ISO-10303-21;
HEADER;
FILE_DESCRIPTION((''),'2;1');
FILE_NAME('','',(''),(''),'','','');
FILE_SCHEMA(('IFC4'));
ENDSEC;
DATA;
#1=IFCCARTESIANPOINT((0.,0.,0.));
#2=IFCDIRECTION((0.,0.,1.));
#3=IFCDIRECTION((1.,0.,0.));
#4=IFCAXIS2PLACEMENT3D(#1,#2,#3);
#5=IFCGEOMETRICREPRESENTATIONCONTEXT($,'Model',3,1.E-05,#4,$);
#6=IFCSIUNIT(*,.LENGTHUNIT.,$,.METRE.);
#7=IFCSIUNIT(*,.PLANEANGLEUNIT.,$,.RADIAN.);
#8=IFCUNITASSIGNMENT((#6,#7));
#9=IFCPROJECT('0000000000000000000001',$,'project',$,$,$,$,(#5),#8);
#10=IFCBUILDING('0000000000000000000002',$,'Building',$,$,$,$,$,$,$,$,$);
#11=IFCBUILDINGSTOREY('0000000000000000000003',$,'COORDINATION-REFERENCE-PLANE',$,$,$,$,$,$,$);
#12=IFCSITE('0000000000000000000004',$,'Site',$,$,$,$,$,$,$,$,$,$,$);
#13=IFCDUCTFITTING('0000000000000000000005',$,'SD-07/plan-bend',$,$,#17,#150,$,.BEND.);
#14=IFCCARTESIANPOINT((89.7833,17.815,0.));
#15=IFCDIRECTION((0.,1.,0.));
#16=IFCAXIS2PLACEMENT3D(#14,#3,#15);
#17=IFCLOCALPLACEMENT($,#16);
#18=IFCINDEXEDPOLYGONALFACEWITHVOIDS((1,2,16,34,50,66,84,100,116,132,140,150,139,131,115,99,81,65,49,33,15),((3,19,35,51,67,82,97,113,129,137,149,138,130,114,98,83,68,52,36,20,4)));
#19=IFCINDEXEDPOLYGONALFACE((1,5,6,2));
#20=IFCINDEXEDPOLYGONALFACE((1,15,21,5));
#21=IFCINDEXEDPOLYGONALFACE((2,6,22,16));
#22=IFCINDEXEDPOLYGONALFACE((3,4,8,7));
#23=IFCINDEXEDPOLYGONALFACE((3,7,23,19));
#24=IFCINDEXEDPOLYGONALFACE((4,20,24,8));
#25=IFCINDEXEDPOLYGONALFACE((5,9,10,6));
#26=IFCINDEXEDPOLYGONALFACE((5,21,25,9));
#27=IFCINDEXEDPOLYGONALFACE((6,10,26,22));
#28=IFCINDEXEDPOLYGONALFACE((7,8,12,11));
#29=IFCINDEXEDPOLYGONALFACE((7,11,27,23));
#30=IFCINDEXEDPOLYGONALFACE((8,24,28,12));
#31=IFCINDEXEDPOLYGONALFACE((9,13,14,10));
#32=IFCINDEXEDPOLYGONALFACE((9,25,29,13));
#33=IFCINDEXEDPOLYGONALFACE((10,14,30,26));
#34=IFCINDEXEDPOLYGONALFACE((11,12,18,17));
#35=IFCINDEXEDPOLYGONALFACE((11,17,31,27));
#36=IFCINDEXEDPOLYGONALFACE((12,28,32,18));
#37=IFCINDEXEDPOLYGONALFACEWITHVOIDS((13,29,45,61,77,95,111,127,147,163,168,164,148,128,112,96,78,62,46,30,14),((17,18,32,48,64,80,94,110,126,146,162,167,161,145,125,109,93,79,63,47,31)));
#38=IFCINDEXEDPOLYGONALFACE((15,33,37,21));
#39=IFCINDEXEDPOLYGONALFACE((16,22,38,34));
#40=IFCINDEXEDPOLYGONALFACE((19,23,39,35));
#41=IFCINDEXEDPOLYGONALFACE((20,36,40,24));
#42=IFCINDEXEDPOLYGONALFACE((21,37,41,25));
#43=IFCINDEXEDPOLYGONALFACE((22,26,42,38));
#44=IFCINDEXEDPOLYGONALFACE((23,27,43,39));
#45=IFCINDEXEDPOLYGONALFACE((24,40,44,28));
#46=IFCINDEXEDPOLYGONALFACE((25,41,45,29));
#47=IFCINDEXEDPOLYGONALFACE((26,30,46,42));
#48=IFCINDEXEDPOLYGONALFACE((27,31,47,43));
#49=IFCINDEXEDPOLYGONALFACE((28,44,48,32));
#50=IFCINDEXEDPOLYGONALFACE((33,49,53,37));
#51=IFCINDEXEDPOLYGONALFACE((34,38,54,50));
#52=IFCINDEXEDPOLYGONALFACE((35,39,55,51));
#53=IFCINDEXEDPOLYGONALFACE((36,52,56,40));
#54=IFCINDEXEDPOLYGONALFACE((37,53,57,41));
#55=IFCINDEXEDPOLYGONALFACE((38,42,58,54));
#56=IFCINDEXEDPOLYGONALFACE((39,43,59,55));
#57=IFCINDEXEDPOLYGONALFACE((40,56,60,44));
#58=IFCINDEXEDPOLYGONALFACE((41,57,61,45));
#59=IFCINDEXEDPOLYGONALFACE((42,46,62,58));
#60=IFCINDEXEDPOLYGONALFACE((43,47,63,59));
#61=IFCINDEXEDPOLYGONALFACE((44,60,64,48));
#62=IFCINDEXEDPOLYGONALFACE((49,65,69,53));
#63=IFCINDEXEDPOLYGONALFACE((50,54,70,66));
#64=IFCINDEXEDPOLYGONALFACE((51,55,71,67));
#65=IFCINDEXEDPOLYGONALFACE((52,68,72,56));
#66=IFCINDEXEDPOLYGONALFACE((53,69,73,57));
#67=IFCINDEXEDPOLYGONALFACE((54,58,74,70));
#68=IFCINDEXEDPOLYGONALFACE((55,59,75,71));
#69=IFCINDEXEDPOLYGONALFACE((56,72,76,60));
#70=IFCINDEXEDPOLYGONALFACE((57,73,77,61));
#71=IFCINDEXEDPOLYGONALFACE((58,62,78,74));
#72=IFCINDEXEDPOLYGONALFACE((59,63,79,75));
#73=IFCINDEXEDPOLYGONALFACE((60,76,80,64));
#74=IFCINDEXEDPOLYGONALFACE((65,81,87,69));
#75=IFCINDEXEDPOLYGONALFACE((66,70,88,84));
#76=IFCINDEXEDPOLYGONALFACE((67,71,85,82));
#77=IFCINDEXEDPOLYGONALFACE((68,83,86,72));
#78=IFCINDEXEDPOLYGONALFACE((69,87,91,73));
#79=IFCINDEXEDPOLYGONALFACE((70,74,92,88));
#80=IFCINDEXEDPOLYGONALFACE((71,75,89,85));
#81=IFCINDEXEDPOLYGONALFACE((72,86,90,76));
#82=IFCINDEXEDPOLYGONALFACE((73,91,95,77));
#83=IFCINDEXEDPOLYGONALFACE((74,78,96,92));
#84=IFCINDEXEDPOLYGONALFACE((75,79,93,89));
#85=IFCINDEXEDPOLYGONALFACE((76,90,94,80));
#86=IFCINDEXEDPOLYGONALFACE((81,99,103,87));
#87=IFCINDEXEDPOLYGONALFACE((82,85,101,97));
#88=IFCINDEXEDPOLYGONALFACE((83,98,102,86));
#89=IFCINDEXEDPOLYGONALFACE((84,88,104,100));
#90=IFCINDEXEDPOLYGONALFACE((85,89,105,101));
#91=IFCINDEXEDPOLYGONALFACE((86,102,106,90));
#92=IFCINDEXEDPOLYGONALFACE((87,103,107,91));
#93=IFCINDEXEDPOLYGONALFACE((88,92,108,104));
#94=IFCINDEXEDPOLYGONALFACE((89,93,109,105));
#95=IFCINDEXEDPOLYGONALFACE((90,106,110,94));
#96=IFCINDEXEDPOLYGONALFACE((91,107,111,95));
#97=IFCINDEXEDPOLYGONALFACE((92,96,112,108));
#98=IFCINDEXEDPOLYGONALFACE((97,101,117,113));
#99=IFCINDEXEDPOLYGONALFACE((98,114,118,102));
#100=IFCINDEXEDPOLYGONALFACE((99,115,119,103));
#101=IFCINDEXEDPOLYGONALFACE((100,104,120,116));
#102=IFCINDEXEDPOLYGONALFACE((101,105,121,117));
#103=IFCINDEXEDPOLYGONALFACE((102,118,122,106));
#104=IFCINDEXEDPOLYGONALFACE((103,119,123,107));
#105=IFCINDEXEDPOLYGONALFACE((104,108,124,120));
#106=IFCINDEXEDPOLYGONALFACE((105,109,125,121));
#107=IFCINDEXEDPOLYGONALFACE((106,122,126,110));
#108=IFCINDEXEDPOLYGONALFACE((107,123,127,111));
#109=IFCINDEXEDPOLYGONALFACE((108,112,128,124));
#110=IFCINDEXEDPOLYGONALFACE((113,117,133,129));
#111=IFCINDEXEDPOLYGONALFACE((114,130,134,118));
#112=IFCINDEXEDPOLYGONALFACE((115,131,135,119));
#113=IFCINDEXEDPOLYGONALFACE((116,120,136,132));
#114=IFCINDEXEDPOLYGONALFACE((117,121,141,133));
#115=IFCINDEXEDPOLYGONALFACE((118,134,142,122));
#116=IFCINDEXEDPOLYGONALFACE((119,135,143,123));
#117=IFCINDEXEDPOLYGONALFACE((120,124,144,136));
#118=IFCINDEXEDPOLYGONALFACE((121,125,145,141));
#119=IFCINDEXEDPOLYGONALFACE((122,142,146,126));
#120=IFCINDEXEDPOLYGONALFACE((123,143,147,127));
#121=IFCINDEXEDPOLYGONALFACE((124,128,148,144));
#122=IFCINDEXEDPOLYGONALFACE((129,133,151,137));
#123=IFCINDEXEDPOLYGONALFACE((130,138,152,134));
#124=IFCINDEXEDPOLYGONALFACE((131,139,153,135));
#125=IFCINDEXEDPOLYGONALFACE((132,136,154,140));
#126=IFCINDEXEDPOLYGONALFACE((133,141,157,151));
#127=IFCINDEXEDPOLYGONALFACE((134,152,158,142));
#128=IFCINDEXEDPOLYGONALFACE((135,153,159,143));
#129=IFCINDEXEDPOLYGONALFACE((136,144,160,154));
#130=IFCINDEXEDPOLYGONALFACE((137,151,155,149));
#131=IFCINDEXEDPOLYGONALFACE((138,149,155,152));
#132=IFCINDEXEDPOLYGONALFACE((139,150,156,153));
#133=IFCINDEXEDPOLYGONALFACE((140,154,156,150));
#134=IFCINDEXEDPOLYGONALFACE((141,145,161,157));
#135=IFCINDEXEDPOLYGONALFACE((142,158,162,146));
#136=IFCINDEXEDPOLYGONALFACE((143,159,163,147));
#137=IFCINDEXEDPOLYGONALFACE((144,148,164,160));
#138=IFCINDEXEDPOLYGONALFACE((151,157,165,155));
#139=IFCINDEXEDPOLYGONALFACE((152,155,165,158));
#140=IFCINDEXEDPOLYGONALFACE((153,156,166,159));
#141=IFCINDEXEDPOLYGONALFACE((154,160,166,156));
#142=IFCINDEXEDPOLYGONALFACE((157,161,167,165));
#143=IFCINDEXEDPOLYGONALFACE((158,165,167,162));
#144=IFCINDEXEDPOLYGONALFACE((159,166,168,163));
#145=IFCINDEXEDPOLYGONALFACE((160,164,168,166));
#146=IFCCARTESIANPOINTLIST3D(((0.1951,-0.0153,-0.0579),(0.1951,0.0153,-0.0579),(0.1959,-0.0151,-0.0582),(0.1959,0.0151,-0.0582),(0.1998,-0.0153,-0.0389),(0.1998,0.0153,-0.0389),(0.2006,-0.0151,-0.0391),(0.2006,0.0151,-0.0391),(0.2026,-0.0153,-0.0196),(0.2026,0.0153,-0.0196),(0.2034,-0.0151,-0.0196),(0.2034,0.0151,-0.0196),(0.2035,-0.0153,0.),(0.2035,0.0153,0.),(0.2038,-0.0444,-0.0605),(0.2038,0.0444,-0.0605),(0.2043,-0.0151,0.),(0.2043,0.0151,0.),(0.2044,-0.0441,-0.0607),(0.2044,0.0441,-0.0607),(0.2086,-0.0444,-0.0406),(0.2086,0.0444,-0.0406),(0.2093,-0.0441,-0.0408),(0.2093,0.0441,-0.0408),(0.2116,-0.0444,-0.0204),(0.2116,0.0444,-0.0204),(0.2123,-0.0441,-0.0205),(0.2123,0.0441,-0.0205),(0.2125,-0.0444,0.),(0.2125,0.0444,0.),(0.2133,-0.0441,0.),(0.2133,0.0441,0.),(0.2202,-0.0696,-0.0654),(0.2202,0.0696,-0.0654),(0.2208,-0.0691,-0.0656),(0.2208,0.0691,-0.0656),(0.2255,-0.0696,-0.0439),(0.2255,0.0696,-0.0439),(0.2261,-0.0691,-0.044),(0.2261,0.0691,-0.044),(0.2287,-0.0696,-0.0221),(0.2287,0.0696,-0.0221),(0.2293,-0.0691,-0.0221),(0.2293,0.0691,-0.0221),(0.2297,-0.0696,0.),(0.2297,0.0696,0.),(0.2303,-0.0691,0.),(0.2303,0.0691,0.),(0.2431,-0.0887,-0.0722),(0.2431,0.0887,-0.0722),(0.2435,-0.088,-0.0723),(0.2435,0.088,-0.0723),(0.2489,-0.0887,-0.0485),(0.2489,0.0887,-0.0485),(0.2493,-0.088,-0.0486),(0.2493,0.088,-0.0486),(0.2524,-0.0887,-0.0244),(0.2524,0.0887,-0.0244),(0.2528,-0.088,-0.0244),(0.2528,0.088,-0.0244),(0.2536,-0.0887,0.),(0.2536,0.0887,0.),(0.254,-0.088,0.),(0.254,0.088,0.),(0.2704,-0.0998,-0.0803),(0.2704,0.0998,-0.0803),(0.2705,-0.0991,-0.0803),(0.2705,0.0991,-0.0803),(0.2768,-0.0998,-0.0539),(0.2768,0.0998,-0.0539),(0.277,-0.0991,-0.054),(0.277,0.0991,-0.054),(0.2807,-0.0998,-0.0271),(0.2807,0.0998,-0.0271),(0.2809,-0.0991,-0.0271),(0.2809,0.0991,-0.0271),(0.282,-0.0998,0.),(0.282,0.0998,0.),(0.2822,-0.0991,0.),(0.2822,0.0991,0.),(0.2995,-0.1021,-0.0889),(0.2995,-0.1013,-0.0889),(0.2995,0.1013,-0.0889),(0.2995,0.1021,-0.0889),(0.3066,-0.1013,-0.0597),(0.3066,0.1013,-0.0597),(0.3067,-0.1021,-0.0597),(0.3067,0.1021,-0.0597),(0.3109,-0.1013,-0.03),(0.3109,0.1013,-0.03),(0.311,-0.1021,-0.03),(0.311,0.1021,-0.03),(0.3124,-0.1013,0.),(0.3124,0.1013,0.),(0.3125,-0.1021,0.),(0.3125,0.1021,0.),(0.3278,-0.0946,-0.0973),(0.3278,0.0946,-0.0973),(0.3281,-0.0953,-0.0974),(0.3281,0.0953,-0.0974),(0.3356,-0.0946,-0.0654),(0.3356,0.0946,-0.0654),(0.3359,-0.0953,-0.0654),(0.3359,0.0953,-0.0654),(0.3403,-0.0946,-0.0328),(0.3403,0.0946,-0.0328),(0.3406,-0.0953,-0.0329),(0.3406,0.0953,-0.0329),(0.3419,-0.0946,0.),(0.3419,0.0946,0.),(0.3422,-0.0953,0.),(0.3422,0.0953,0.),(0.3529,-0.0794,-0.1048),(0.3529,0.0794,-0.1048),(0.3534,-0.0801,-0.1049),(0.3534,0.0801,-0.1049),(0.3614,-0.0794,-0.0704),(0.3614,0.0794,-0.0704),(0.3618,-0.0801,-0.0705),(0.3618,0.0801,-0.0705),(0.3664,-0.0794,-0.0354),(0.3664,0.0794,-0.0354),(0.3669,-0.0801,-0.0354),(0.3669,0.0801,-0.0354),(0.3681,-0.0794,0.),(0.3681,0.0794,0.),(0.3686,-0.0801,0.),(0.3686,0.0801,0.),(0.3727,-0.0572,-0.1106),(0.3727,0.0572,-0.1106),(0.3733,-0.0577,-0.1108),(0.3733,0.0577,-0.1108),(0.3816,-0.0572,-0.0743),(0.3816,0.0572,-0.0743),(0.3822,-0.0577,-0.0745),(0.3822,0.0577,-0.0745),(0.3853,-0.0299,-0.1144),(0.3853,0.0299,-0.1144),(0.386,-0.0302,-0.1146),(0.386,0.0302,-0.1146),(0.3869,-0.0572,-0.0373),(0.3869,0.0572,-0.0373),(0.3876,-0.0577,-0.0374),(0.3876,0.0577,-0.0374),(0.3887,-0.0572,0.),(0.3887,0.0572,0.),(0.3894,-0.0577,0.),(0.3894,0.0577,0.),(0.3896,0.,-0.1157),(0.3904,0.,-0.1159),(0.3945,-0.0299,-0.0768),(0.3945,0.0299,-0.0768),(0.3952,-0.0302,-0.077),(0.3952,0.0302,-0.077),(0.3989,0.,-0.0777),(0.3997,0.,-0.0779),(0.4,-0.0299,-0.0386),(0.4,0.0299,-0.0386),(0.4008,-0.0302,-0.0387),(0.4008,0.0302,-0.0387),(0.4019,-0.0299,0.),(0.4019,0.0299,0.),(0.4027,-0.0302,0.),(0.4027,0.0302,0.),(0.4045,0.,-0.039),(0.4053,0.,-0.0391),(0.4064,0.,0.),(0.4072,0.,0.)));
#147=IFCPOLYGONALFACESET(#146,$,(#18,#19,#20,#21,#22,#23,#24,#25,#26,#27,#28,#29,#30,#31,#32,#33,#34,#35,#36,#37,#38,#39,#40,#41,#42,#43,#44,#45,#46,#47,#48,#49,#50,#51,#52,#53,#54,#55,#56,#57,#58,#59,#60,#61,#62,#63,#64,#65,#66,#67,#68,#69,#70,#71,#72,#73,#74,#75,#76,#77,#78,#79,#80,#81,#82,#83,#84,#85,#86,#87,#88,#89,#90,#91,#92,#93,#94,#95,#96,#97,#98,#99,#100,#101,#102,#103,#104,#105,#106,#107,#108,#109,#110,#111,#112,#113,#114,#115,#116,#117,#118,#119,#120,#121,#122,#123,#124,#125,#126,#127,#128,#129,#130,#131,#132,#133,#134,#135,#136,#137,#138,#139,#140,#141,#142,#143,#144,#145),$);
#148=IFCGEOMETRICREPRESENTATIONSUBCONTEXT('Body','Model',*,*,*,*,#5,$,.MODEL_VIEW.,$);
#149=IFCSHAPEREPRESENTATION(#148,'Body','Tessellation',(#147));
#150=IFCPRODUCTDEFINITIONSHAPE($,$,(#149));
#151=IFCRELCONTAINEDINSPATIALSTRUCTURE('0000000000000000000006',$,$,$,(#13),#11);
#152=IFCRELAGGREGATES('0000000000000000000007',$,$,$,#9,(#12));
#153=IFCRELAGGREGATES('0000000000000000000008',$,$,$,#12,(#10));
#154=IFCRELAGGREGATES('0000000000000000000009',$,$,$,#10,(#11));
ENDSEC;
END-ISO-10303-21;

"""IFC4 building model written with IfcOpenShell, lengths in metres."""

from ifc_helpers import new_model, entity, si_unit, frame, origin_with_axes, place, context, subcontext, project, spatial, element, save


model = new_model("IFC4")

# Units and contexts
model_context = context("Model", 3, precision=1e-05, world=origin_with_axes())
body_context_1 = subcontext(model_context, "Body", "Model", "MODEL_VIEW")
ifc_project = project(units=[si_unit("LENGTHUNIT", "METRE"), si_unit("PLANEANGLEUNIT", "RADIAN")], contexts=[model_context])

# Site, building, storey
site = spatial("IfcSite", under=ifc_project, Name="Site")
building = spatial("IfcBuilding", under=site, Name="Building")
storey = spatial("IfcBuildingStorey", under=building, Name="COORDINATION-REFERENCE-PLANE")

# Duct fitting
duct_fitting_1_placement = place(None, frame((89.7833, 17.815, 0.0), z_axis=(1.0, 0.0, 0.0), x_axis=(0.0, 1.0, 0.0)))
element("IfcDuctFitting", 1, at=duct_fitting_1_placement, inside=storey, Name="SD-07/plan-bend", PredefinedType="BEND", context=body_context_1, shape_type="SweptSolid", body=[
    entity("IfcRevolvedAreaSolid", entity("IfcCircleHollowProfileDef", "AREA", None, entity("IfcAxis2Placement2D", entity("IfcCartesianPoint", [0.3048, 0.0])), 0.1024, 0.0008), entity("IfcAxis2Placement3D", entity("IfcCartesianPoint", [0.0, 0.0, 0.0]), entity("IfcDirection", [0.0, 0.0, 1.0]), entity("IfcDirection", [1.0, 0.0, 0.0])), entity("IfcAxis1Placement", entity("IfcCartesianPoint", [0.0, 0.0, 0.0]), entity("IfcDirection", [0.0, 1.0, 0.0])), 0.288593),
])

save(model, "model.ifc")
